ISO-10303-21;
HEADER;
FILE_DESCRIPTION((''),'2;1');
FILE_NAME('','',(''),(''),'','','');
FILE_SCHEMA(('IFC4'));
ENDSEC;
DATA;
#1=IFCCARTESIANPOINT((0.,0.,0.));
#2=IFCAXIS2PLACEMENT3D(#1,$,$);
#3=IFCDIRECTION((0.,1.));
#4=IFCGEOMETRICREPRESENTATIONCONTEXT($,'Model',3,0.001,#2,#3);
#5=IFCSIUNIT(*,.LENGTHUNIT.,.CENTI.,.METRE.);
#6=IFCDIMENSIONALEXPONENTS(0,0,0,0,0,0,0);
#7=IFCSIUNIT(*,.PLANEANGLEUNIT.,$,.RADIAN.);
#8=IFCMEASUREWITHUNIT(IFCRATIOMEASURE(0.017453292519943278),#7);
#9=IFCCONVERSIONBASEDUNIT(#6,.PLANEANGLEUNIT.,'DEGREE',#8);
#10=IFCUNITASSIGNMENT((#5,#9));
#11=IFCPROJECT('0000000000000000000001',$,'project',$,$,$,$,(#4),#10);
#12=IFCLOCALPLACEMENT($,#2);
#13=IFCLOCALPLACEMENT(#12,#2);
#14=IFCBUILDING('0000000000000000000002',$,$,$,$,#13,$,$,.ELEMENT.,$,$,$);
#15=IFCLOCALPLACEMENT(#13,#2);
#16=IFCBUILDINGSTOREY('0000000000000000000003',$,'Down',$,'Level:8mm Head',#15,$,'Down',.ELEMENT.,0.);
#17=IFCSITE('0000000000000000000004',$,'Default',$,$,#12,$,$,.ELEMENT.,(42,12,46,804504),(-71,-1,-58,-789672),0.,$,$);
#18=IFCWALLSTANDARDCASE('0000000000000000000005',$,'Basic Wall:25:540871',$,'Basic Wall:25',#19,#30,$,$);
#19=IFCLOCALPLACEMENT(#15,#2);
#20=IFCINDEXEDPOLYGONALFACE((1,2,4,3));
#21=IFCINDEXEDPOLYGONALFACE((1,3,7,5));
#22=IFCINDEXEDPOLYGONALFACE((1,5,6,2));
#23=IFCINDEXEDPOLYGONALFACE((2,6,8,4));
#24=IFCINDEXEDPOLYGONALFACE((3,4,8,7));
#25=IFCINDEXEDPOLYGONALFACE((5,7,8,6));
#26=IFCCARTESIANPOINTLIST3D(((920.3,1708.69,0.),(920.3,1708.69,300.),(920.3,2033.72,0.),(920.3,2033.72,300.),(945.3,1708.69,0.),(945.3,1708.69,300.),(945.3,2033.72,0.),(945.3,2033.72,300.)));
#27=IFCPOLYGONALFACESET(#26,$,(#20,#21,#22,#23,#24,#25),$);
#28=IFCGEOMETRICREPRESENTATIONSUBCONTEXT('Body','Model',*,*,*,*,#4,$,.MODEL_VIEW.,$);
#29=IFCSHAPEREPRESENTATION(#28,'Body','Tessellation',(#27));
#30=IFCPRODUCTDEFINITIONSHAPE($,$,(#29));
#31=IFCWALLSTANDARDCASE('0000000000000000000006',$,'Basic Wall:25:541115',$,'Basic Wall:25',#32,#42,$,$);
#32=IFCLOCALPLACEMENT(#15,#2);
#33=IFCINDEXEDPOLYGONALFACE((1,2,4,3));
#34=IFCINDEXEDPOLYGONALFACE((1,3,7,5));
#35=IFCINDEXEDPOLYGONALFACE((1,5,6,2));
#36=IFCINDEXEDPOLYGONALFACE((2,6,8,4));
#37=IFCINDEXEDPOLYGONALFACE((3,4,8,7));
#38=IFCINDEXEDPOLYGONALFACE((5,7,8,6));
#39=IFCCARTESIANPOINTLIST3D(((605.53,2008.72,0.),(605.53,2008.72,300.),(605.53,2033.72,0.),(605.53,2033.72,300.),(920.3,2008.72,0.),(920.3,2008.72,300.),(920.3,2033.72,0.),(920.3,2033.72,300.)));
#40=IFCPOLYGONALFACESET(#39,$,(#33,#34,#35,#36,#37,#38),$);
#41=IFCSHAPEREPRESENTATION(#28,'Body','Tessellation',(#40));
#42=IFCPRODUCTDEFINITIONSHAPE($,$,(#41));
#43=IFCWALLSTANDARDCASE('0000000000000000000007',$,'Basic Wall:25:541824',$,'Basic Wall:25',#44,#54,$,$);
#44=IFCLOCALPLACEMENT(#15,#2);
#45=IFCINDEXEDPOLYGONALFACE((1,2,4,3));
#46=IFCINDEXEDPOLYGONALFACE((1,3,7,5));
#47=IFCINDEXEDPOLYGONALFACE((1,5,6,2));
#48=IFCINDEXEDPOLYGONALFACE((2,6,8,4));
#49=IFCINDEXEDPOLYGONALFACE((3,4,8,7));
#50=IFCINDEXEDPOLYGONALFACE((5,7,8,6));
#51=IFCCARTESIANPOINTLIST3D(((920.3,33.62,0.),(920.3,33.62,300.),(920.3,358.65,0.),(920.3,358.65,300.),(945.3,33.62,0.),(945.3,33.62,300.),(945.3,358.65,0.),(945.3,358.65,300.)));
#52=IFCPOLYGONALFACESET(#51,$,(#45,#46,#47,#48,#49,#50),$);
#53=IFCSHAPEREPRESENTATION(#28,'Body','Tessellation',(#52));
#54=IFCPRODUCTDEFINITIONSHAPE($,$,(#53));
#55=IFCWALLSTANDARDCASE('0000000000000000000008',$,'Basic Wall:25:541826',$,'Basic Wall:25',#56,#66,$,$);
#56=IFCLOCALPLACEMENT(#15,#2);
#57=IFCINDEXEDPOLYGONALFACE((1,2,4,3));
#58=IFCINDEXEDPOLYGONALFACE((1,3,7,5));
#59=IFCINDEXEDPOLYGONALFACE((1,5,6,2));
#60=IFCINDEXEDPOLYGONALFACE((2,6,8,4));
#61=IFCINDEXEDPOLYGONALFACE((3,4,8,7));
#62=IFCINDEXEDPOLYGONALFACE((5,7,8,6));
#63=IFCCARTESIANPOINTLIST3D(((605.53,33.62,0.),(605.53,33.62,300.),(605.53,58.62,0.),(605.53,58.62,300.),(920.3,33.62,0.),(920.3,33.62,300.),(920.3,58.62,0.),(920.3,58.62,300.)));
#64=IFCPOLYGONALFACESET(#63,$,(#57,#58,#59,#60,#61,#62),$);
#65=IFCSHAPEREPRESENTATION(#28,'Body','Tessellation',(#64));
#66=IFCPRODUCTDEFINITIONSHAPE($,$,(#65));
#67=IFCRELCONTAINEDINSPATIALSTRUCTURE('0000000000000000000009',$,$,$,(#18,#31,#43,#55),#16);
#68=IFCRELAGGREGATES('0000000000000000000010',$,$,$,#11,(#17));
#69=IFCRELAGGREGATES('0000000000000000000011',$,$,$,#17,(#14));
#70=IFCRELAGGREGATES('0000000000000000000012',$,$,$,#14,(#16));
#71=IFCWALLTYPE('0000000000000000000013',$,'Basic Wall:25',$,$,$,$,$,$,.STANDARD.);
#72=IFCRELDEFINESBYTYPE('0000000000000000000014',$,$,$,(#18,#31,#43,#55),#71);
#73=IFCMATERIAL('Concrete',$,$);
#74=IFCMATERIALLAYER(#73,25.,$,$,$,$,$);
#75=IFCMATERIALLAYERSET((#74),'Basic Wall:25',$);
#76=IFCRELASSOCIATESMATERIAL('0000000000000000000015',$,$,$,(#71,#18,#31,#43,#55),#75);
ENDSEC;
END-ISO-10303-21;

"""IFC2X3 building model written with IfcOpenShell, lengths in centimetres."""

from ifc_helpers import new_model, entity, si_unit, converted_unit, direction, frame, frame_2d, origin, place, context, subcontext, project, spatial, rectangle, extrude, material, layer, layer_set, layer_usage, type_object, element, save


model = new_model("IFC2X3")

# Units and contexts
model_context = context("Model", 3, precision=0.001, world=origin(), true_north=direction((0.0, 1.0)))
body_context = subcontext(model_context, "Body", "Model", "MODEL_VIEW")
ifc_project = project(units=[si_unit("LENGTHUNIT", "METRE", prefix="CENTI"), converted_unit("PLANEANGLEUNIT", "DEGREE", entity("IfcRatioMeasure", 0.017453292519943278), si_unit("PLANEANGLEUNIT", "RADIAN"), dimensions=[0, 0, 0, 0, 0, 0, 0])], contexts=[model_context])

# Site, building, storey
site_placement = place(None, origin())
site = spatial("IfcSite", under=ifc_project, at=site_placement, Name="Default", CompositionType="ELEMENT", RefLatitude=(42, 12, 46, 804504), RefLongitude=(-71, -1, -58, -789672), RefElevation=0.0)
building_placement = place(site_placement, origin())
building = spatial("IfcBuilding", under=site, at=building_placement, CompositionType="ELEMENT")
storey_placement = place(building_placement, origin())
storey = spatial("IfcBuildingStorey", under=building, at=storey_placement, Name="Down", ObjectType="Level:8mm Head", LongName="Down", CompositionType="ELEMENT", Elevation=0.0)

# Shared definitions
ifc_material = material(Name="Concrete")

# Walls
ifc_layer_1 = layer(ifc_material, 25.0)
ifc_layer_set_1 = layer_set([ifc_layer_1], Name="Basic Wall:25")
ifc_layer_usage_1 = layer_usage(ifc_layer_set_1, "AXIS2", "POSITIVE", -12.5)
wall_type_1 = type_object("IfcWallType", Name="Basic Wall:25", PredefinedType="STANDARD", material=ifc_layer_set_1)
wall_1_placement = place(storey_placement, frame((932.8, 1708.69, 0.0), z_axis=(0.0, 0.0, 1.0), x_axis=(0.0, 1.0, 0.0)))
element("IfcWallStandardCase", 1, at=wall_1_placement, inside=storey, type_object=wall_type_1, material=ifc_layer_usage_1, Name="Basic Wall:25:540871", ObjectType="Basic Wall:25", context=body_context, shape_type="SweptSolid", body=[
    extrude(rectangle(XDim=325.03, YDim=25.0, at=frame_2d((162.51, 0.0), x_axis=(-1.0, 0.0))), origin(), (0.0, 0.0, 1.0), 300.0),
])
ifc_layer_usage_2 = layer_usage(ifc_layer_set_1, "AXIS2", "POSITIVE", -12.5)
wall_2_placement = place(storey_placement, frame((920.3, 2021.22, 0.0), z_axis=(0.0, 0.0, 1.0), x_axis=(-1.0, 0.0, 0.0)))
element("IfcWallStandardCase", 2, at=wall_2_placement, inside=storey, type_object=wall_type_1, material=ifc_layer_usage_2, Name="Basic Wall:25:541115", ObjectType="Basic Wall:25", context=body_context, shape_type="SweptSolid", body=[
    extrude(rectangle(XDim=314.77, YDim=25.0, at=frame_2d((157.38, 0.0), x_axis=(-1.0, 0.0))), origin(), (0.0, 0.0, 1.0), 300.0),
])
ifc_layer_usage_3 = layer_usage(ifc_layer_set_1, "AXIS2", "NEGATIVE", 12.5)
wall_3_placement = place(storey_placement, frame((932.8, 358.65, 0.0), z_axis=(0.0, 0.0, 1.0), x_axis=(0.0, -1.0, 0.0)))
element("IfcWallStandardCase", 3, at=wall_3_placement, inside=storey, type_object=wall_type_1, material=ifc_layer_usage_3, Name="Basic Wall:25:541824", ObjectType="Basic Wall:25", context=body_context, shape_type="SweptSolid", body=[
    extrude(rectangle(XDim=325.03, YDim=25.0, at=frame_2d((162.51, 0.0), x_axis=(-1.0, 0.0))), origin(), (0.0, 0.0, 1.0), 300.0),
])
ifc_layer_usage_4 = layer_usage(ifc_layer_set_1, "AXIS2", "NEGATIVE", 12.5)
wall_4_placement = place(storey_placement, frame((920.3, 46.12, 0.0), z_axis=(0.0, 0.0, 1.0), x_axis=(-1.0, 0.0, 0.0)))
element("IfcWallStandardCase", 4, at=wall_4_placement, inside=storey, type_object=wall_type_1, material=ifc_layer_usage_4, Name="Basic Wall:25:541826", ObjectType="Basic Wall:25", context=body_context, shape_type="SweptSolid", body=[
    extrude(rectangle(XDim=314.77, YDim=25.0, at=frame_2d((157.38, 0.0), x_axis=(-1.0, 0.0))), origin(), (0.0, 0.0, 1.0), 300.0),
])

save(model, "model.ifc")
